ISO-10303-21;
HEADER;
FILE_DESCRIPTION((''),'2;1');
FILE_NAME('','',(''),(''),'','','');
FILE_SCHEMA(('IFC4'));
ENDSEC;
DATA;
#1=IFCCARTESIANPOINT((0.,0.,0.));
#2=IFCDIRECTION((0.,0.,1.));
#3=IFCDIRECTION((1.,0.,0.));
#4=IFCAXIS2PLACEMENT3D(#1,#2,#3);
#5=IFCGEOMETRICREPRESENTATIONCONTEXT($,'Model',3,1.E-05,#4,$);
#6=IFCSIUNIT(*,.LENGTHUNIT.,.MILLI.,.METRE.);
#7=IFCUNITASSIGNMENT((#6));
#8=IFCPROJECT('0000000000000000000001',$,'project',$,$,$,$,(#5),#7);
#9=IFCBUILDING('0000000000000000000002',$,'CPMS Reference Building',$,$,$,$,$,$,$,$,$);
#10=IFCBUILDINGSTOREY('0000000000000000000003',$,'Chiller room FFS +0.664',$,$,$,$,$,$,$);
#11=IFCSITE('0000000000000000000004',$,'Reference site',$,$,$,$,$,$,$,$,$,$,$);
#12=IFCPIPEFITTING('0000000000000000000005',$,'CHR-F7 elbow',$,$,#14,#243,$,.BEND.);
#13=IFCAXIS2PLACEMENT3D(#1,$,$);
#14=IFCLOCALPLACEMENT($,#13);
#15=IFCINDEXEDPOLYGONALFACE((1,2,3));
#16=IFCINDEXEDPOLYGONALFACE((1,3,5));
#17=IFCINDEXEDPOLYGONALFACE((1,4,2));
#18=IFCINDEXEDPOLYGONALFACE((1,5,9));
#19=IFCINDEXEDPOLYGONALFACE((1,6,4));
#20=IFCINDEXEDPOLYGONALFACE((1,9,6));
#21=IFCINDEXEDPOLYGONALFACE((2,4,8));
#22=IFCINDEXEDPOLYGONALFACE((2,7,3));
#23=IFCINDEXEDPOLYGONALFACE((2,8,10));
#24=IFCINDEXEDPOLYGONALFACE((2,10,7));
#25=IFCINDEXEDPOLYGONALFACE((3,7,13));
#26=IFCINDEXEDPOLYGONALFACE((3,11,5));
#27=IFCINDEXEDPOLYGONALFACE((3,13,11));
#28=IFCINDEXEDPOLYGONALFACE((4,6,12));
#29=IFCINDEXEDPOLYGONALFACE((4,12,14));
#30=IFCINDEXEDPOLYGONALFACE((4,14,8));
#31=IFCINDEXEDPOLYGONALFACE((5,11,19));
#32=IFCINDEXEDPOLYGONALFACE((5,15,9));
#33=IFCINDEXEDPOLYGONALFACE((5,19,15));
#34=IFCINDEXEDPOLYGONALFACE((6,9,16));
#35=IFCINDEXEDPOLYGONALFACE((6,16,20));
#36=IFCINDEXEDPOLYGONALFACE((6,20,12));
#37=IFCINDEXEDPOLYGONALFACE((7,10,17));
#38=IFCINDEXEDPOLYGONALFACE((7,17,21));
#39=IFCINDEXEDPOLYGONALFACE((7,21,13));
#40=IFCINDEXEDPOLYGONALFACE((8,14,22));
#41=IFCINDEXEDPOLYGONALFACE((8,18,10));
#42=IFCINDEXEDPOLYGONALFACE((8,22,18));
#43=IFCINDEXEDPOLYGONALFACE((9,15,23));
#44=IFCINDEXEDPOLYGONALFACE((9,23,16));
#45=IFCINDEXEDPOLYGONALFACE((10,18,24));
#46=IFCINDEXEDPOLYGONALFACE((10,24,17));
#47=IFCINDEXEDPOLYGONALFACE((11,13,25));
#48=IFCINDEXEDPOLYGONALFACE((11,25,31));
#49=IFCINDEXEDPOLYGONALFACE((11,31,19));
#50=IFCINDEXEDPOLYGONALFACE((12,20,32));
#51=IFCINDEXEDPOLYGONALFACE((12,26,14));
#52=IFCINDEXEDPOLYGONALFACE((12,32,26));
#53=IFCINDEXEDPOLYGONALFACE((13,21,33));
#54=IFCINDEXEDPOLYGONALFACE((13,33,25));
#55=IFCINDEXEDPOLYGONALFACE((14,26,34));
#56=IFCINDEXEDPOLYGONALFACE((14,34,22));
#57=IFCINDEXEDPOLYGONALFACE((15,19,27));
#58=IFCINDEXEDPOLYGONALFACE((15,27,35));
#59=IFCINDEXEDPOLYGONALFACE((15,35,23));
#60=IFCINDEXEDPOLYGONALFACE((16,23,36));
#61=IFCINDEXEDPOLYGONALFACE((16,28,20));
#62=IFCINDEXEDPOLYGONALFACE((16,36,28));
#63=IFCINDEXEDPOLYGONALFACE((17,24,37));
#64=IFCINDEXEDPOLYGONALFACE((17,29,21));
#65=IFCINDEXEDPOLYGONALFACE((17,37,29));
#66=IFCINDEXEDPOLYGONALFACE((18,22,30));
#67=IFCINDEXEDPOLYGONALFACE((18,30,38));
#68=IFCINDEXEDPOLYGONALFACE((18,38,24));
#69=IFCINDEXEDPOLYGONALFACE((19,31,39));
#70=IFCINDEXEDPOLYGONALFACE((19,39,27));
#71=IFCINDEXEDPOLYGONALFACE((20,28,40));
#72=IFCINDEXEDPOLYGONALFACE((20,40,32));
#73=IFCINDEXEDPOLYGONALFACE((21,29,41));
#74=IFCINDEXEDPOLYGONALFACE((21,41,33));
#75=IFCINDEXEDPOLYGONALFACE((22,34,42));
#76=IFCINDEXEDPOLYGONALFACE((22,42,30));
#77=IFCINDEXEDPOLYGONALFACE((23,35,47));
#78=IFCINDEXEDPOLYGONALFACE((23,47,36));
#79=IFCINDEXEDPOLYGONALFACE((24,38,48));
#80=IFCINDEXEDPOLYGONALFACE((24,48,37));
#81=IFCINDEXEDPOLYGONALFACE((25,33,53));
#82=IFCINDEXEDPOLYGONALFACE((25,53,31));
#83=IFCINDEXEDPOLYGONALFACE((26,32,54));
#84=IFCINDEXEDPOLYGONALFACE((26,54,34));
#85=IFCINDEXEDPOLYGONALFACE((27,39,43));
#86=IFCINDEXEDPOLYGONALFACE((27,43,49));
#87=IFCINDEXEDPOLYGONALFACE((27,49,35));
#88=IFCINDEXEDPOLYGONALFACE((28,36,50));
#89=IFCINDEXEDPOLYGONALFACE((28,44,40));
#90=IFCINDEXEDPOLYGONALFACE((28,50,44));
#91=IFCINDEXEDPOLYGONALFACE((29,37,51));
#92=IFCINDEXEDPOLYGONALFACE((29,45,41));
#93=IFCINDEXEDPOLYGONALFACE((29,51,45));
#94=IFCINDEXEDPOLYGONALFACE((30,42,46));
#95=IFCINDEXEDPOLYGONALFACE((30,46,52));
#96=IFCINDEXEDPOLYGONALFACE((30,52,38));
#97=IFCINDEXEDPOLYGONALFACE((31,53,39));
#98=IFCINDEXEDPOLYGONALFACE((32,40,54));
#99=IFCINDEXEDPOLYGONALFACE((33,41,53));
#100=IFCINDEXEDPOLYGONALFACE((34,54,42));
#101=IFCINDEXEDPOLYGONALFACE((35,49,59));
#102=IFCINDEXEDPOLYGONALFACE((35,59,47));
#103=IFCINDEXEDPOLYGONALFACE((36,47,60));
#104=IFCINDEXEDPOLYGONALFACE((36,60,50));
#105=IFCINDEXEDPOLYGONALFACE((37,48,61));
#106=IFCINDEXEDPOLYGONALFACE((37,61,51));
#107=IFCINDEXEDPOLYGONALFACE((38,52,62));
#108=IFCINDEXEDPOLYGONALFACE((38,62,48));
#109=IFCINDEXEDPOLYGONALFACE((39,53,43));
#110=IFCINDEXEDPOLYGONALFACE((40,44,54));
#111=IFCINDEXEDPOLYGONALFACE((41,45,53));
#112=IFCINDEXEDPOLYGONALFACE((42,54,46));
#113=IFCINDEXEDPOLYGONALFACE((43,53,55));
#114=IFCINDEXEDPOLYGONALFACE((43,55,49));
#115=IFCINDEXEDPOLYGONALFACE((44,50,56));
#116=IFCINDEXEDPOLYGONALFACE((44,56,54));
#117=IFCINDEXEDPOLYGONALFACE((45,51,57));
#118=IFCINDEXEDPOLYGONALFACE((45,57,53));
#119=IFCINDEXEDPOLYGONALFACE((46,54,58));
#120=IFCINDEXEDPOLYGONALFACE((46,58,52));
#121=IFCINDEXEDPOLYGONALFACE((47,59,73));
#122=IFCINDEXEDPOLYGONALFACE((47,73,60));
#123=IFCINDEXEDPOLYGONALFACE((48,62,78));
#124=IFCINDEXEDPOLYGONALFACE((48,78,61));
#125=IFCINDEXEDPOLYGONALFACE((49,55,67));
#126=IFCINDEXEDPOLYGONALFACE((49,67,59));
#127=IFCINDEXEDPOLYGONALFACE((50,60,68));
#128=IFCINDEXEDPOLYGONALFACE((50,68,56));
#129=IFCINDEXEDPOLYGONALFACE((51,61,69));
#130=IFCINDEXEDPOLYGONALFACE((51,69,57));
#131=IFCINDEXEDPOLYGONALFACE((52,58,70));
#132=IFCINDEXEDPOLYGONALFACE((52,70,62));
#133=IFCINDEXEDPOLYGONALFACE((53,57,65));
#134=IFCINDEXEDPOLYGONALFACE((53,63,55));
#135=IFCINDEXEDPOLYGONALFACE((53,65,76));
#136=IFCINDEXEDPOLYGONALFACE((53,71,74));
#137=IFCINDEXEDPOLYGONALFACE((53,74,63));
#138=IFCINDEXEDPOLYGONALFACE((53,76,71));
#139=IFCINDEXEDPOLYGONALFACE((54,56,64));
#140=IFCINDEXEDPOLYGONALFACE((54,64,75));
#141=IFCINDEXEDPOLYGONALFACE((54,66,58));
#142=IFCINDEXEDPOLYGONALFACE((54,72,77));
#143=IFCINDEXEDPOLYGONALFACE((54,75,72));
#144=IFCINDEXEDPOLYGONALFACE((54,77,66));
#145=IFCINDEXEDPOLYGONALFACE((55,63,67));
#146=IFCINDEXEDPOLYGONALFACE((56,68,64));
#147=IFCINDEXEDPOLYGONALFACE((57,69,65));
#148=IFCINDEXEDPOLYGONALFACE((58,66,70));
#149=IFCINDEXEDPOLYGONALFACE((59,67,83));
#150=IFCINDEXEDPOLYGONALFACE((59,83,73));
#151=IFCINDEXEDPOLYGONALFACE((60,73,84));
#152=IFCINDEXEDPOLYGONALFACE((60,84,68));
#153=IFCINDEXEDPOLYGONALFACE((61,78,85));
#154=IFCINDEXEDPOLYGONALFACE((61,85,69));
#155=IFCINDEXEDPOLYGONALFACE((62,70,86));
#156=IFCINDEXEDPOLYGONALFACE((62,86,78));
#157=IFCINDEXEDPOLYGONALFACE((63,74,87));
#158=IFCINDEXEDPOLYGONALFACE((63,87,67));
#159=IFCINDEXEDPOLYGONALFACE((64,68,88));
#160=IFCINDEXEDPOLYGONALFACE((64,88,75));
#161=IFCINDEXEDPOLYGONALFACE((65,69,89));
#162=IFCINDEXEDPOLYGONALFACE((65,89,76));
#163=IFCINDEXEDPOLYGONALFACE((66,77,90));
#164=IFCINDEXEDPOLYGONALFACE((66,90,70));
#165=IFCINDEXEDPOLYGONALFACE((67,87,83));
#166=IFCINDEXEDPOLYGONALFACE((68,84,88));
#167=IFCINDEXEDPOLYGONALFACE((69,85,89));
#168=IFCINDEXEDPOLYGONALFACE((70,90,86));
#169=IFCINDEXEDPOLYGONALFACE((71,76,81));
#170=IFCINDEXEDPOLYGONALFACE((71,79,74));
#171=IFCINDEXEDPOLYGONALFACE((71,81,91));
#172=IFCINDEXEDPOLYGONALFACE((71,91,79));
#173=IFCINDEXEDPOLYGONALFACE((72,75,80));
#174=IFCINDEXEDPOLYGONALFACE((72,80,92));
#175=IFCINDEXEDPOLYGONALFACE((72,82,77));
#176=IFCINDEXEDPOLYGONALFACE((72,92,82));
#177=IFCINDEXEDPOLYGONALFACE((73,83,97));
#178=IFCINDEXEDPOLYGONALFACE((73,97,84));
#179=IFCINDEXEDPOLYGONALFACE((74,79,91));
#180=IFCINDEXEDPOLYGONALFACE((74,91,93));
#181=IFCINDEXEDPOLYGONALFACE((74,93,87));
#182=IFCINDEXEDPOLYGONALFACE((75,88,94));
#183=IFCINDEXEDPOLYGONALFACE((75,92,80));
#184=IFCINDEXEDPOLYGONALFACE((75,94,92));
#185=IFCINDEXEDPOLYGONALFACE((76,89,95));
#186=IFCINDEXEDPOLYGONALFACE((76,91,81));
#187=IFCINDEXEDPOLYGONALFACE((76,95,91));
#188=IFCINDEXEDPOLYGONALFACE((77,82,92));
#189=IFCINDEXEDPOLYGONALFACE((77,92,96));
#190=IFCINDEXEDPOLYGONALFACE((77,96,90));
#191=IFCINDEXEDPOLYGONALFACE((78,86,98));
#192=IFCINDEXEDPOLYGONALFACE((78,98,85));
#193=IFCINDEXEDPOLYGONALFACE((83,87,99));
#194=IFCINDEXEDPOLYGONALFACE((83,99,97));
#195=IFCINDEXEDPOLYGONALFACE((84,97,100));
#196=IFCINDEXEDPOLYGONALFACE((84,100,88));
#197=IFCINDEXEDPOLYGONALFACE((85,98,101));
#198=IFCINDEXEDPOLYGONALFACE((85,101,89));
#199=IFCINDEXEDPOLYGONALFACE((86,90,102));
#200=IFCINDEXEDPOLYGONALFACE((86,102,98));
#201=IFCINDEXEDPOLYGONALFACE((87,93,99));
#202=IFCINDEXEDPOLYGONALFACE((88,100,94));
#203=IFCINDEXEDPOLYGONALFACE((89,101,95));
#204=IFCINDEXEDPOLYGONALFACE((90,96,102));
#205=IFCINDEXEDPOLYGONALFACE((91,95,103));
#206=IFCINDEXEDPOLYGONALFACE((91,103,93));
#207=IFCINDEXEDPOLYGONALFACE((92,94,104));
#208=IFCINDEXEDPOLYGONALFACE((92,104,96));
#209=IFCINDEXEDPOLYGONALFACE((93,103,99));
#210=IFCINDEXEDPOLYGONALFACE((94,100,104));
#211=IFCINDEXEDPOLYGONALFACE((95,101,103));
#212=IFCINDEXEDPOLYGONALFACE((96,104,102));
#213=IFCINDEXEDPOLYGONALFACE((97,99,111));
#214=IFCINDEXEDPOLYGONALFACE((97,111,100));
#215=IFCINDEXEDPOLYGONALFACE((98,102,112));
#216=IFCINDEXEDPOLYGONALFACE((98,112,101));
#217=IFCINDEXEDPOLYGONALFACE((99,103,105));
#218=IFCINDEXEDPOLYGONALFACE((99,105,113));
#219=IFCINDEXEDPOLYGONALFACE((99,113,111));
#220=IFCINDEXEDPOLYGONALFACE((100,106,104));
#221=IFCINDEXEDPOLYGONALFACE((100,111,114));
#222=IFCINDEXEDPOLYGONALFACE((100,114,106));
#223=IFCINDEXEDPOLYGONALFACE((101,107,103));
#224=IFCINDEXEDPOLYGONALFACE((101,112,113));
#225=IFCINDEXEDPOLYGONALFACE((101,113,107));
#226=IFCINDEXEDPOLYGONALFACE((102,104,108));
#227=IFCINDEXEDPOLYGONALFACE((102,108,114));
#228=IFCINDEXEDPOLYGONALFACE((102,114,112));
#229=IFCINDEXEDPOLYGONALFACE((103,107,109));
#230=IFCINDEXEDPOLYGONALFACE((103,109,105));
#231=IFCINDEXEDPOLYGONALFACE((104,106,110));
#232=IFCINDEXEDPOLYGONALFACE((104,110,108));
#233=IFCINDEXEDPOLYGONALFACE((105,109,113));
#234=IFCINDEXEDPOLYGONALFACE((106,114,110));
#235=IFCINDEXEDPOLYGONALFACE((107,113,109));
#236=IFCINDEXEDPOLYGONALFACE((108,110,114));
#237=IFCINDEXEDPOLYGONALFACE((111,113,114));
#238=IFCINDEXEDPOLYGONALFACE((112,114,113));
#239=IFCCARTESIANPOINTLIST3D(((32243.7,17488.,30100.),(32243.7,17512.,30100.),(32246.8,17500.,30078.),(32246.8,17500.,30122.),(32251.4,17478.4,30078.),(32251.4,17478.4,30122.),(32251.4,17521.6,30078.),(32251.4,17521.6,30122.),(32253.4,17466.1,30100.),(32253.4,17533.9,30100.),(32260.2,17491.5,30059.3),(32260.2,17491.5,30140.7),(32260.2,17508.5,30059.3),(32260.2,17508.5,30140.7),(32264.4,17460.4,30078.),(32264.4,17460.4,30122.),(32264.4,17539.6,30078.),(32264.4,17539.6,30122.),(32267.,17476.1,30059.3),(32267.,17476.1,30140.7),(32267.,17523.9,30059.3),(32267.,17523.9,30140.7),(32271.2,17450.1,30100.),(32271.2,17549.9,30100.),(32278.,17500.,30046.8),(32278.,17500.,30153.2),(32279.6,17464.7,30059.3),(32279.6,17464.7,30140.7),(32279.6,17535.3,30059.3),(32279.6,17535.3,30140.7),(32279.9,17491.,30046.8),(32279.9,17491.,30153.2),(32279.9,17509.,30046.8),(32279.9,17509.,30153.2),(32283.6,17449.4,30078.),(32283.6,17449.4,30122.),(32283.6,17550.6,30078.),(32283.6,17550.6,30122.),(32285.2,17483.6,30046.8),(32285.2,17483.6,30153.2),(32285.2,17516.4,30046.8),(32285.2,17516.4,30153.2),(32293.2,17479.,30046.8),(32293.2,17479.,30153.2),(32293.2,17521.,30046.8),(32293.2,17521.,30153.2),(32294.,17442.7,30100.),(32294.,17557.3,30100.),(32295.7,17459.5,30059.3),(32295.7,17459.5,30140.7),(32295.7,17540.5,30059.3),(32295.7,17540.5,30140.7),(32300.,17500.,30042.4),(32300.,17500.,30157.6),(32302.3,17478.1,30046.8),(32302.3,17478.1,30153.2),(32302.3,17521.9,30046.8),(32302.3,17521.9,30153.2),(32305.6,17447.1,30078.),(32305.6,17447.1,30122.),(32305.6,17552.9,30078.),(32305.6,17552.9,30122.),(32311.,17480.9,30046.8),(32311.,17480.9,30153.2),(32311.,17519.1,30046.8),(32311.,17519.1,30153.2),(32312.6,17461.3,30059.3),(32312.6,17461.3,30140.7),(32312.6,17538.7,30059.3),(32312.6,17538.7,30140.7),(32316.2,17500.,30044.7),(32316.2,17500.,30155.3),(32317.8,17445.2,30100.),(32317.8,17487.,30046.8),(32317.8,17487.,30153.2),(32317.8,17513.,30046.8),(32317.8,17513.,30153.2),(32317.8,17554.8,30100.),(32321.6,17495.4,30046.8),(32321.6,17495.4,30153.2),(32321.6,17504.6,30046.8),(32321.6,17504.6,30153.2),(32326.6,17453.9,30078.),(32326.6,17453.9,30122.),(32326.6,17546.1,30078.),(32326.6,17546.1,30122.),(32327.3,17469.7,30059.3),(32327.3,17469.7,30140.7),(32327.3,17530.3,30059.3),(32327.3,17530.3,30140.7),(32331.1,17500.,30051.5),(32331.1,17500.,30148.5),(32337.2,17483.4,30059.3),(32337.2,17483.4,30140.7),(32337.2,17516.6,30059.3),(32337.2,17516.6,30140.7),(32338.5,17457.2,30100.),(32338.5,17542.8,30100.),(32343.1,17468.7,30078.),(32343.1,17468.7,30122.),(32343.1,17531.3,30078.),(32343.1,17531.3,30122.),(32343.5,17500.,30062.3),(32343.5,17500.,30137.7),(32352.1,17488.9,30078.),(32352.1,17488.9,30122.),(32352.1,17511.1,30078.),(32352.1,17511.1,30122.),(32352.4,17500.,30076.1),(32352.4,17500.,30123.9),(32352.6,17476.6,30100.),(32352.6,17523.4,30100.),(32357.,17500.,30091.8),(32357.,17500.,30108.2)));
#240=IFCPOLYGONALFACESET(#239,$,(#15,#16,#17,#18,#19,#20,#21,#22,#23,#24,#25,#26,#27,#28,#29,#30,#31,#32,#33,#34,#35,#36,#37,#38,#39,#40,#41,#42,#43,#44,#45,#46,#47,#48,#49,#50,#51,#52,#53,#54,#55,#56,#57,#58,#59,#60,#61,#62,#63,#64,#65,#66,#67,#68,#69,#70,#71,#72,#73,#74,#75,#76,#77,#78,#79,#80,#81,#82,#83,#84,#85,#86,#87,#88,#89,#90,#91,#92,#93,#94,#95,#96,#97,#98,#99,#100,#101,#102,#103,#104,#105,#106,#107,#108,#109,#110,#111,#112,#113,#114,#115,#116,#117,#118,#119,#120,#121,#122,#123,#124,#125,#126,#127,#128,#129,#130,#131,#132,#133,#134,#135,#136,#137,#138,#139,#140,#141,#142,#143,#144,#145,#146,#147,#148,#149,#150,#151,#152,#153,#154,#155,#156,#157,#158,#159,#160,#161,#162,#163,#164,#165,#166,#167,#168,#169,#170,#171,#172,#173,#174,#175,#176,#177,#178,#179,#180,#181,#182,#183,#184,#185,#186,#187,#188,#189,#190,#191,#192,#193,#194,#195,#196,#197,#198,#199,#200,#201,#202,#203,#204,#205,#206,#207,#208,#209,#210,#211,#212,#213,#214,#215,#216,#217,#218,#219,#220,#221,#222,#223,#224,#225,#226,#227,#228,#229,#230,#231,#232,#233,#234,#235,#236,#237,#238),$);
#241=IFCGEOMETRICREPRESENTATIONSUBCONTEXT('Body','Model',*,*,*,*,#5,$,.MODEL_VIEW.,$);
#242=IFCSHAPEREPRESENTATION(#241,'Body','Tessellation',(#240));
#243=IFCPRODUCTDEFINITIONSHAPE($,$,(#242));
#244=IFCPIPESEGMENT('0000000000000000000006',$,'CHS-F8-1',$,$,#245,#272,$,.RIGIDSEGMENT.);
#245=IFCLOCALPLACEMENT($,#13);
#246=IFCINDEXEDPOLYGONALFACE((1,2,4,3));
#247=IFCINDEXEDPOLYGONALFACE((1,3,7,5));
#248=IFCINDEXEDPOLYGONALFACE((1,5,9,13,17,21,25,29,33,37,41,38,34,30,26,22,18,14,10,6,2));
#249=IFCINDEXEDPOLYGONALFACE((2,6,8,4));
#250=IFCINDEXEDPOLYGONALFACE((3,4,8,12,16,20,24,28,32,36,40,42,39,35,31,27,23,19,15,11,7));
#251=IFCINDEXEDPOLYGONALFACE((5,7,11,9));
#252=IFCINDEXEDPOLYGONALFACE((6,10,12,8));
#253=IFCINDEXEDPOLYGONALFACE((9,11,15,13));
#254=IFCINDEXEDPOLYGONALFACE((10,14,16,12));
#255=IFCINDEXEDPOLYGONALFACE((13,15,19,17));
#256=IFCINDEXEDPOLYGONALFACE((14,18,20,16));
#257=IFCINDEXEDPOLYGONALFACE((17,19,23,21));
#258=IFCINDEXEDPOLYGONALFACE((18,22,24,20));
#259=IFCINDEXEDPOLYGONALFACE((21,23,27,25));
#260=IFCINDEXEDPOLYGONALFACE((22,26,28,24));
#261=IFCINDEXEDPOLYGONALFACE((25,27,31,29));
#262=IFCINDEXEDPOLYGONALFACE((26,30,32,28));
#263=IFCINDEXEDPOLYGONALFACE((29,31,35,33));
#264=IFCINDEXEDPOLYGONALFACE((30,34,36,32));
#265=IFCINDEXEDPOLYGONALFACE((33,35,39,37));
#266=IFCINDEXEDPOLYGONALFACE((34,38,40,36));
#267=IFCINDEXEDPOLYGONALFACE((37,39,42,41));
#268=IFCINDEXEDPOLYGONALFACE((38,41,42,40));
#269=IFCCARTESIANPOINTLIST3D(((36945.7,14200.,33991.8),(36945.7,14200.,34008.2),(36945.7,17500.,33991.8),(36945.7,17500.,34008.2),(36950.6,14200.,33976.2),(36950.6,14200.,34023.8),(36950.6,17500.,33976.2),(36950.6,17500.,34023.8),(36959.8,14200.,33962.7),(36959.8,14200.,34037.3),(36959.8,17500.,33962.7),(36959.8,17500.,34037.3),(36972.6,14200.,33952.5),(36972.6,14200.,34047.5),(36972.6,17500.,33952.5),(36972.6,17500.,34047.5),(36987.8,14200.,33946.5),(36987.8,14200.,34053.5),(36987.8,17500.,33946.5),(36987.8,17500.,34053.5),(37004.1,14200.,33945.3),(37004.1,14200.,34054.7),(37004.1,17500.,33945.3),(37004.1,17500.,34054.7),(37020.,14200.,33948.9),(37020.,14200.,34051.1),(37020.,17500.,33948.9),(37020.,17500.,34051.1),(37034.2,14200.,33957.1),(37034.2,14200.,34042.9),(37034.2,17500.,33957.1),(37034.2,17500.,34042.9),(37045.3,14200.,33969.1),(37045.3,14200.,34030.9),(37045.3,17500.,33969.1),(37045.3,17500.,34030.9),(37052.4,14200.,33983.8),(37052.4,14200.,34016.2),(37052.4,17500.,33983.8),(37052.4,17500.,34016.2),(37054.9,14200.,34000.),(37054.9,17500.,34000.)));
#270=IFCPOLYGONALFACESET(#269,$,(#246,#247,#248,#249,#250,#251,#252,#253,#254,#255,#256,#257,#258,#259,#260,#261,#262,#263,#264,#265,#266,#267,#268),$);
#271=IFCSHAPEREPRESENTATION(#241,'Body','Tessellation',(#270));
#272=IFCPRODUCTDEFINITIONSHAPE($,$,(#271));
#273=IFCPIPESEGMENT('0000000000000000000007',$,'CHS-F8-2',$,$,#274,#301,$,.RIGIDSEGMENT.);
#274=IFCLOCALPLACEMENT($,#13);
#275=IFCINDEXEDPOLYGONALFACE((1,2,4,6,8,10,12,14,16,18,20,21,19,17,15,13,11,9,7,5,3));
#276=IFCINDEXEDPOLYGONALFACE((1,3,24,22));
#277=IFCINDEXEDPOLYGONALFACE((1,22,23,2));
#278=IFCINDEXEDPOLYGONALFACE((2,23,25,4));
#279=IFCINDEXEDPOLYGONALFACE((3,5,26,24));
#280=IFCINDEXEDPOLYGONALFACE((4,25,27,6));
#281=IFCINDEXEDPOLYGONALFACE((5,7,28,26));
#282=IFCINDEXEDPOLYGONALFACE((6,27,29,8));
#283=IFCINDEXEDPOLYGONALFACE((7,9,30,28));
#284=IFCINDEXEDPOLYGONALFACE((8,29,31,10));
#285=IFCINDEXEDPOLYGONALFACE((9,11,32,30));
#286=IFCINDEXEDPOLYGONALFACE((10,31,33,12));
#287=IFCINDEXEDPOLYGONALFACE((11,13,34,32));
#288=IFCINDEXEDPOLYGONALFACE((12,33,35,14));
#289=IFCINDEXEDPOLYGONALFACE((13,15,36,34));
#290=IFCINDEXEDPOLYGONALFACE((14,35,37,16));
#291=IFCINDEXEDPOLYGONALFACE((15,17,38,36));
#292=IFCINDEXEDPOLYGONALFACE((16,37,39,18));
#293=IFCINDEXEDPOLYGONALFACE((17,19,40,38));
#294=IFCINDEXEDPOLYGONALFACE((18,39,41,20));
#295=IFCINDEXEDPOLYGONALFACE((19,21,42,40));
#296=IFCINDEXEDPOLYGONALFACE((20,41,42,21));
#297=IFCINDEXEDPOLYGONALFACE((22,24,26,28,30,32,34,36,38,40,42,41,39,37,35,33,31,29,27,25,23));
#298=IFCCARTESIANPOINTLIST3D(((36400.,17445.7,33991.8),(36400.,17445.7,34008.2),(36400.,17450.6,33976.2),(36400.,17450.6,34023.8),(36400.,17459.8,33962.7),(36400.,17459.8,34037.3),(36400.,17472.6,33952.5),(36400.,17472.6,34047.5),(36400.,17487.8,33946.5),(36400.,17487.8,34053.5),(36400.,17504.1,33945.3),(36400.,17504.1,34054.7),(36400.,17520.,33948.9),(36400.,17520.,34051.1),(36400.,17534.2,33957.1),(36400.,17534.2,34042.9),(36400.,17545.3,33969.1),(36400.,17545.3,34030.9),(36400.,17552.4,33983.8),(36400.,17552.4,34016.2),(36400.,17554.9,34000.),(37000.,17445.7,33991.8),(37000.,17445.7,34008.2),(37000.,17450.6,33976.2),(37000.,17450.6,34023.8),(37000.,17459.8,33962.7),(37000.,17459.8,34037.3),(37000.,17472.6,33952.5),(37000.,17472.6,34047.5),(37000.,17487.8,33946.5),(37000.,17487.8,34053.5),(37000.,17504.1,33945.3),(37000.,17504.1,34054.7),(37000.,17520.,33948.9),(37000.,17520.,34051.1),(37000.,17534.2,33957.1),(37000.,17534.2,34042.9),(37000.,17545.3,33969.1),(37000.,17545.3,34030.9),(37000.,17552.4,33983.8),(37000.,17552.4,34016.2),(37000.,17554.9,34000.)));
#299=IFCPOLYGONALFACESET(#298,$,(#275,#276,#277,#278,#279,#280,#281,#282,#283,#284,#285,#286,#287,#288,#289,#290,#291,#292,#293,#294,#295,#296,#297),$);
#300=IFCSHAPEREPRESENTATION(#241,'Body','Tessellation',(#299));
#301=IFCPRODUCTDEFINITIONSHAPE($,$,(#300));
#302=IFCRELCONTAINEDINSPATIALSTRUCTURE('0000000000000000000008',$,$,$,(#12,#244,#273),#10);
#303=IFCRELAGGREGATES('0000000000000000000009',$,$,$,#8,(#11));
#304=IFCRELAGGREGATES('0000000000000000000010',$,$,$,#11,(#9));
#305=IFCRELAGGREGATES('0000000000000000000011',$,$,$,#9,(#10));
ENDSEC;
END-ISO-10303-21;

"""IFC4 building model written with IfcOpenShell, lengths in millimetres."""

from ifc_helpers import new_model, entity, si_unit, frame, origin_with_axes, origin_2d, place, context, subcontext, project, spatial, circle_curve, outline, extrude, element, save


model = new_model("IFC4")

# Units and contexts
model_context = context("Model", 3, precision=1e-05, world=origin_with_axes())
body_context = subcontext(model_context, "Body", "Model", "MODEL_VIEW")
ifc_project = project(units=[si_unit("LENGTHUNIT", "METRE", prefix="MILLI")], contexts=[model_context])

# Site, building, storey
site = spatial("IfcSite", under=ifc_project, Name="Reference site")
building = spatial("IfcBuilding", under=site, Name="CPMS Reference Building")
storey = spatial("IfcBuildingStorey", under=building, Name="Chiller room FFS +0.664")

# Pipe fitting
pipe_fitting_1_placement = place(None, origin_with_axes())
element("IfcPipeFitting", 1, at=pipe_fitting_1_placement, inside=storey, Name="CHR-F7 elbow", PredefinedType="BEND", context=body_context, shape_type="CSG", body=[
    entity("IfcSphere", entity("IfcAxis2Placement3D", entity("IfcCartesianPoint", [32300.0, 17500.0, 30100.0]), entity("IfcDirection", [0.0, 0.0, 1.0]), entity("IfcDirection", [1.0, 0.0, 0.0])), 57.6),
])

# Pipe segments
pipe_segment_1_placement = place(None, origin_with_axes())
element("IfcPipeSegment", 2, at=pipe_segment_1_placement, inside=storey, Name="CHS-F8-1", PredefinedType="RIGIDSEGMENT", context=body_context, shape_type="SweptSolid", body=[
    extrude(outline(circle_curve(origin_2d(), 54.9)), frame((37000.0, 14200.0, 34000.0), z_axis=(0.0, 1.0, 0.0), x_axis=(1.0, 0.0, 0.0)), (0.0, 0.0, 1.0), 3300.0),
])
pipe_segment_2_placement = place(None, origin_with_axes())
element("IfcPipeSegment", 3, at=pipe_segment_2_placement, inside=storey, Name="CHS-F8-2", PredefinedType="RIGIDSEGMENT", context=body_context, shape_type="SweptSolid", body=[
    extrude(outline(circle_curve(origin_2d(), 54.9)), frame((37000.0, 17500.0, 34000.0), z_axis=(-1.0, 0.0, 0.0), x_axis=(0.0, 1.0, 0.0)), (0.0, 0.0, 1.0), 600.0),
])

save(model, "model.ifc")
